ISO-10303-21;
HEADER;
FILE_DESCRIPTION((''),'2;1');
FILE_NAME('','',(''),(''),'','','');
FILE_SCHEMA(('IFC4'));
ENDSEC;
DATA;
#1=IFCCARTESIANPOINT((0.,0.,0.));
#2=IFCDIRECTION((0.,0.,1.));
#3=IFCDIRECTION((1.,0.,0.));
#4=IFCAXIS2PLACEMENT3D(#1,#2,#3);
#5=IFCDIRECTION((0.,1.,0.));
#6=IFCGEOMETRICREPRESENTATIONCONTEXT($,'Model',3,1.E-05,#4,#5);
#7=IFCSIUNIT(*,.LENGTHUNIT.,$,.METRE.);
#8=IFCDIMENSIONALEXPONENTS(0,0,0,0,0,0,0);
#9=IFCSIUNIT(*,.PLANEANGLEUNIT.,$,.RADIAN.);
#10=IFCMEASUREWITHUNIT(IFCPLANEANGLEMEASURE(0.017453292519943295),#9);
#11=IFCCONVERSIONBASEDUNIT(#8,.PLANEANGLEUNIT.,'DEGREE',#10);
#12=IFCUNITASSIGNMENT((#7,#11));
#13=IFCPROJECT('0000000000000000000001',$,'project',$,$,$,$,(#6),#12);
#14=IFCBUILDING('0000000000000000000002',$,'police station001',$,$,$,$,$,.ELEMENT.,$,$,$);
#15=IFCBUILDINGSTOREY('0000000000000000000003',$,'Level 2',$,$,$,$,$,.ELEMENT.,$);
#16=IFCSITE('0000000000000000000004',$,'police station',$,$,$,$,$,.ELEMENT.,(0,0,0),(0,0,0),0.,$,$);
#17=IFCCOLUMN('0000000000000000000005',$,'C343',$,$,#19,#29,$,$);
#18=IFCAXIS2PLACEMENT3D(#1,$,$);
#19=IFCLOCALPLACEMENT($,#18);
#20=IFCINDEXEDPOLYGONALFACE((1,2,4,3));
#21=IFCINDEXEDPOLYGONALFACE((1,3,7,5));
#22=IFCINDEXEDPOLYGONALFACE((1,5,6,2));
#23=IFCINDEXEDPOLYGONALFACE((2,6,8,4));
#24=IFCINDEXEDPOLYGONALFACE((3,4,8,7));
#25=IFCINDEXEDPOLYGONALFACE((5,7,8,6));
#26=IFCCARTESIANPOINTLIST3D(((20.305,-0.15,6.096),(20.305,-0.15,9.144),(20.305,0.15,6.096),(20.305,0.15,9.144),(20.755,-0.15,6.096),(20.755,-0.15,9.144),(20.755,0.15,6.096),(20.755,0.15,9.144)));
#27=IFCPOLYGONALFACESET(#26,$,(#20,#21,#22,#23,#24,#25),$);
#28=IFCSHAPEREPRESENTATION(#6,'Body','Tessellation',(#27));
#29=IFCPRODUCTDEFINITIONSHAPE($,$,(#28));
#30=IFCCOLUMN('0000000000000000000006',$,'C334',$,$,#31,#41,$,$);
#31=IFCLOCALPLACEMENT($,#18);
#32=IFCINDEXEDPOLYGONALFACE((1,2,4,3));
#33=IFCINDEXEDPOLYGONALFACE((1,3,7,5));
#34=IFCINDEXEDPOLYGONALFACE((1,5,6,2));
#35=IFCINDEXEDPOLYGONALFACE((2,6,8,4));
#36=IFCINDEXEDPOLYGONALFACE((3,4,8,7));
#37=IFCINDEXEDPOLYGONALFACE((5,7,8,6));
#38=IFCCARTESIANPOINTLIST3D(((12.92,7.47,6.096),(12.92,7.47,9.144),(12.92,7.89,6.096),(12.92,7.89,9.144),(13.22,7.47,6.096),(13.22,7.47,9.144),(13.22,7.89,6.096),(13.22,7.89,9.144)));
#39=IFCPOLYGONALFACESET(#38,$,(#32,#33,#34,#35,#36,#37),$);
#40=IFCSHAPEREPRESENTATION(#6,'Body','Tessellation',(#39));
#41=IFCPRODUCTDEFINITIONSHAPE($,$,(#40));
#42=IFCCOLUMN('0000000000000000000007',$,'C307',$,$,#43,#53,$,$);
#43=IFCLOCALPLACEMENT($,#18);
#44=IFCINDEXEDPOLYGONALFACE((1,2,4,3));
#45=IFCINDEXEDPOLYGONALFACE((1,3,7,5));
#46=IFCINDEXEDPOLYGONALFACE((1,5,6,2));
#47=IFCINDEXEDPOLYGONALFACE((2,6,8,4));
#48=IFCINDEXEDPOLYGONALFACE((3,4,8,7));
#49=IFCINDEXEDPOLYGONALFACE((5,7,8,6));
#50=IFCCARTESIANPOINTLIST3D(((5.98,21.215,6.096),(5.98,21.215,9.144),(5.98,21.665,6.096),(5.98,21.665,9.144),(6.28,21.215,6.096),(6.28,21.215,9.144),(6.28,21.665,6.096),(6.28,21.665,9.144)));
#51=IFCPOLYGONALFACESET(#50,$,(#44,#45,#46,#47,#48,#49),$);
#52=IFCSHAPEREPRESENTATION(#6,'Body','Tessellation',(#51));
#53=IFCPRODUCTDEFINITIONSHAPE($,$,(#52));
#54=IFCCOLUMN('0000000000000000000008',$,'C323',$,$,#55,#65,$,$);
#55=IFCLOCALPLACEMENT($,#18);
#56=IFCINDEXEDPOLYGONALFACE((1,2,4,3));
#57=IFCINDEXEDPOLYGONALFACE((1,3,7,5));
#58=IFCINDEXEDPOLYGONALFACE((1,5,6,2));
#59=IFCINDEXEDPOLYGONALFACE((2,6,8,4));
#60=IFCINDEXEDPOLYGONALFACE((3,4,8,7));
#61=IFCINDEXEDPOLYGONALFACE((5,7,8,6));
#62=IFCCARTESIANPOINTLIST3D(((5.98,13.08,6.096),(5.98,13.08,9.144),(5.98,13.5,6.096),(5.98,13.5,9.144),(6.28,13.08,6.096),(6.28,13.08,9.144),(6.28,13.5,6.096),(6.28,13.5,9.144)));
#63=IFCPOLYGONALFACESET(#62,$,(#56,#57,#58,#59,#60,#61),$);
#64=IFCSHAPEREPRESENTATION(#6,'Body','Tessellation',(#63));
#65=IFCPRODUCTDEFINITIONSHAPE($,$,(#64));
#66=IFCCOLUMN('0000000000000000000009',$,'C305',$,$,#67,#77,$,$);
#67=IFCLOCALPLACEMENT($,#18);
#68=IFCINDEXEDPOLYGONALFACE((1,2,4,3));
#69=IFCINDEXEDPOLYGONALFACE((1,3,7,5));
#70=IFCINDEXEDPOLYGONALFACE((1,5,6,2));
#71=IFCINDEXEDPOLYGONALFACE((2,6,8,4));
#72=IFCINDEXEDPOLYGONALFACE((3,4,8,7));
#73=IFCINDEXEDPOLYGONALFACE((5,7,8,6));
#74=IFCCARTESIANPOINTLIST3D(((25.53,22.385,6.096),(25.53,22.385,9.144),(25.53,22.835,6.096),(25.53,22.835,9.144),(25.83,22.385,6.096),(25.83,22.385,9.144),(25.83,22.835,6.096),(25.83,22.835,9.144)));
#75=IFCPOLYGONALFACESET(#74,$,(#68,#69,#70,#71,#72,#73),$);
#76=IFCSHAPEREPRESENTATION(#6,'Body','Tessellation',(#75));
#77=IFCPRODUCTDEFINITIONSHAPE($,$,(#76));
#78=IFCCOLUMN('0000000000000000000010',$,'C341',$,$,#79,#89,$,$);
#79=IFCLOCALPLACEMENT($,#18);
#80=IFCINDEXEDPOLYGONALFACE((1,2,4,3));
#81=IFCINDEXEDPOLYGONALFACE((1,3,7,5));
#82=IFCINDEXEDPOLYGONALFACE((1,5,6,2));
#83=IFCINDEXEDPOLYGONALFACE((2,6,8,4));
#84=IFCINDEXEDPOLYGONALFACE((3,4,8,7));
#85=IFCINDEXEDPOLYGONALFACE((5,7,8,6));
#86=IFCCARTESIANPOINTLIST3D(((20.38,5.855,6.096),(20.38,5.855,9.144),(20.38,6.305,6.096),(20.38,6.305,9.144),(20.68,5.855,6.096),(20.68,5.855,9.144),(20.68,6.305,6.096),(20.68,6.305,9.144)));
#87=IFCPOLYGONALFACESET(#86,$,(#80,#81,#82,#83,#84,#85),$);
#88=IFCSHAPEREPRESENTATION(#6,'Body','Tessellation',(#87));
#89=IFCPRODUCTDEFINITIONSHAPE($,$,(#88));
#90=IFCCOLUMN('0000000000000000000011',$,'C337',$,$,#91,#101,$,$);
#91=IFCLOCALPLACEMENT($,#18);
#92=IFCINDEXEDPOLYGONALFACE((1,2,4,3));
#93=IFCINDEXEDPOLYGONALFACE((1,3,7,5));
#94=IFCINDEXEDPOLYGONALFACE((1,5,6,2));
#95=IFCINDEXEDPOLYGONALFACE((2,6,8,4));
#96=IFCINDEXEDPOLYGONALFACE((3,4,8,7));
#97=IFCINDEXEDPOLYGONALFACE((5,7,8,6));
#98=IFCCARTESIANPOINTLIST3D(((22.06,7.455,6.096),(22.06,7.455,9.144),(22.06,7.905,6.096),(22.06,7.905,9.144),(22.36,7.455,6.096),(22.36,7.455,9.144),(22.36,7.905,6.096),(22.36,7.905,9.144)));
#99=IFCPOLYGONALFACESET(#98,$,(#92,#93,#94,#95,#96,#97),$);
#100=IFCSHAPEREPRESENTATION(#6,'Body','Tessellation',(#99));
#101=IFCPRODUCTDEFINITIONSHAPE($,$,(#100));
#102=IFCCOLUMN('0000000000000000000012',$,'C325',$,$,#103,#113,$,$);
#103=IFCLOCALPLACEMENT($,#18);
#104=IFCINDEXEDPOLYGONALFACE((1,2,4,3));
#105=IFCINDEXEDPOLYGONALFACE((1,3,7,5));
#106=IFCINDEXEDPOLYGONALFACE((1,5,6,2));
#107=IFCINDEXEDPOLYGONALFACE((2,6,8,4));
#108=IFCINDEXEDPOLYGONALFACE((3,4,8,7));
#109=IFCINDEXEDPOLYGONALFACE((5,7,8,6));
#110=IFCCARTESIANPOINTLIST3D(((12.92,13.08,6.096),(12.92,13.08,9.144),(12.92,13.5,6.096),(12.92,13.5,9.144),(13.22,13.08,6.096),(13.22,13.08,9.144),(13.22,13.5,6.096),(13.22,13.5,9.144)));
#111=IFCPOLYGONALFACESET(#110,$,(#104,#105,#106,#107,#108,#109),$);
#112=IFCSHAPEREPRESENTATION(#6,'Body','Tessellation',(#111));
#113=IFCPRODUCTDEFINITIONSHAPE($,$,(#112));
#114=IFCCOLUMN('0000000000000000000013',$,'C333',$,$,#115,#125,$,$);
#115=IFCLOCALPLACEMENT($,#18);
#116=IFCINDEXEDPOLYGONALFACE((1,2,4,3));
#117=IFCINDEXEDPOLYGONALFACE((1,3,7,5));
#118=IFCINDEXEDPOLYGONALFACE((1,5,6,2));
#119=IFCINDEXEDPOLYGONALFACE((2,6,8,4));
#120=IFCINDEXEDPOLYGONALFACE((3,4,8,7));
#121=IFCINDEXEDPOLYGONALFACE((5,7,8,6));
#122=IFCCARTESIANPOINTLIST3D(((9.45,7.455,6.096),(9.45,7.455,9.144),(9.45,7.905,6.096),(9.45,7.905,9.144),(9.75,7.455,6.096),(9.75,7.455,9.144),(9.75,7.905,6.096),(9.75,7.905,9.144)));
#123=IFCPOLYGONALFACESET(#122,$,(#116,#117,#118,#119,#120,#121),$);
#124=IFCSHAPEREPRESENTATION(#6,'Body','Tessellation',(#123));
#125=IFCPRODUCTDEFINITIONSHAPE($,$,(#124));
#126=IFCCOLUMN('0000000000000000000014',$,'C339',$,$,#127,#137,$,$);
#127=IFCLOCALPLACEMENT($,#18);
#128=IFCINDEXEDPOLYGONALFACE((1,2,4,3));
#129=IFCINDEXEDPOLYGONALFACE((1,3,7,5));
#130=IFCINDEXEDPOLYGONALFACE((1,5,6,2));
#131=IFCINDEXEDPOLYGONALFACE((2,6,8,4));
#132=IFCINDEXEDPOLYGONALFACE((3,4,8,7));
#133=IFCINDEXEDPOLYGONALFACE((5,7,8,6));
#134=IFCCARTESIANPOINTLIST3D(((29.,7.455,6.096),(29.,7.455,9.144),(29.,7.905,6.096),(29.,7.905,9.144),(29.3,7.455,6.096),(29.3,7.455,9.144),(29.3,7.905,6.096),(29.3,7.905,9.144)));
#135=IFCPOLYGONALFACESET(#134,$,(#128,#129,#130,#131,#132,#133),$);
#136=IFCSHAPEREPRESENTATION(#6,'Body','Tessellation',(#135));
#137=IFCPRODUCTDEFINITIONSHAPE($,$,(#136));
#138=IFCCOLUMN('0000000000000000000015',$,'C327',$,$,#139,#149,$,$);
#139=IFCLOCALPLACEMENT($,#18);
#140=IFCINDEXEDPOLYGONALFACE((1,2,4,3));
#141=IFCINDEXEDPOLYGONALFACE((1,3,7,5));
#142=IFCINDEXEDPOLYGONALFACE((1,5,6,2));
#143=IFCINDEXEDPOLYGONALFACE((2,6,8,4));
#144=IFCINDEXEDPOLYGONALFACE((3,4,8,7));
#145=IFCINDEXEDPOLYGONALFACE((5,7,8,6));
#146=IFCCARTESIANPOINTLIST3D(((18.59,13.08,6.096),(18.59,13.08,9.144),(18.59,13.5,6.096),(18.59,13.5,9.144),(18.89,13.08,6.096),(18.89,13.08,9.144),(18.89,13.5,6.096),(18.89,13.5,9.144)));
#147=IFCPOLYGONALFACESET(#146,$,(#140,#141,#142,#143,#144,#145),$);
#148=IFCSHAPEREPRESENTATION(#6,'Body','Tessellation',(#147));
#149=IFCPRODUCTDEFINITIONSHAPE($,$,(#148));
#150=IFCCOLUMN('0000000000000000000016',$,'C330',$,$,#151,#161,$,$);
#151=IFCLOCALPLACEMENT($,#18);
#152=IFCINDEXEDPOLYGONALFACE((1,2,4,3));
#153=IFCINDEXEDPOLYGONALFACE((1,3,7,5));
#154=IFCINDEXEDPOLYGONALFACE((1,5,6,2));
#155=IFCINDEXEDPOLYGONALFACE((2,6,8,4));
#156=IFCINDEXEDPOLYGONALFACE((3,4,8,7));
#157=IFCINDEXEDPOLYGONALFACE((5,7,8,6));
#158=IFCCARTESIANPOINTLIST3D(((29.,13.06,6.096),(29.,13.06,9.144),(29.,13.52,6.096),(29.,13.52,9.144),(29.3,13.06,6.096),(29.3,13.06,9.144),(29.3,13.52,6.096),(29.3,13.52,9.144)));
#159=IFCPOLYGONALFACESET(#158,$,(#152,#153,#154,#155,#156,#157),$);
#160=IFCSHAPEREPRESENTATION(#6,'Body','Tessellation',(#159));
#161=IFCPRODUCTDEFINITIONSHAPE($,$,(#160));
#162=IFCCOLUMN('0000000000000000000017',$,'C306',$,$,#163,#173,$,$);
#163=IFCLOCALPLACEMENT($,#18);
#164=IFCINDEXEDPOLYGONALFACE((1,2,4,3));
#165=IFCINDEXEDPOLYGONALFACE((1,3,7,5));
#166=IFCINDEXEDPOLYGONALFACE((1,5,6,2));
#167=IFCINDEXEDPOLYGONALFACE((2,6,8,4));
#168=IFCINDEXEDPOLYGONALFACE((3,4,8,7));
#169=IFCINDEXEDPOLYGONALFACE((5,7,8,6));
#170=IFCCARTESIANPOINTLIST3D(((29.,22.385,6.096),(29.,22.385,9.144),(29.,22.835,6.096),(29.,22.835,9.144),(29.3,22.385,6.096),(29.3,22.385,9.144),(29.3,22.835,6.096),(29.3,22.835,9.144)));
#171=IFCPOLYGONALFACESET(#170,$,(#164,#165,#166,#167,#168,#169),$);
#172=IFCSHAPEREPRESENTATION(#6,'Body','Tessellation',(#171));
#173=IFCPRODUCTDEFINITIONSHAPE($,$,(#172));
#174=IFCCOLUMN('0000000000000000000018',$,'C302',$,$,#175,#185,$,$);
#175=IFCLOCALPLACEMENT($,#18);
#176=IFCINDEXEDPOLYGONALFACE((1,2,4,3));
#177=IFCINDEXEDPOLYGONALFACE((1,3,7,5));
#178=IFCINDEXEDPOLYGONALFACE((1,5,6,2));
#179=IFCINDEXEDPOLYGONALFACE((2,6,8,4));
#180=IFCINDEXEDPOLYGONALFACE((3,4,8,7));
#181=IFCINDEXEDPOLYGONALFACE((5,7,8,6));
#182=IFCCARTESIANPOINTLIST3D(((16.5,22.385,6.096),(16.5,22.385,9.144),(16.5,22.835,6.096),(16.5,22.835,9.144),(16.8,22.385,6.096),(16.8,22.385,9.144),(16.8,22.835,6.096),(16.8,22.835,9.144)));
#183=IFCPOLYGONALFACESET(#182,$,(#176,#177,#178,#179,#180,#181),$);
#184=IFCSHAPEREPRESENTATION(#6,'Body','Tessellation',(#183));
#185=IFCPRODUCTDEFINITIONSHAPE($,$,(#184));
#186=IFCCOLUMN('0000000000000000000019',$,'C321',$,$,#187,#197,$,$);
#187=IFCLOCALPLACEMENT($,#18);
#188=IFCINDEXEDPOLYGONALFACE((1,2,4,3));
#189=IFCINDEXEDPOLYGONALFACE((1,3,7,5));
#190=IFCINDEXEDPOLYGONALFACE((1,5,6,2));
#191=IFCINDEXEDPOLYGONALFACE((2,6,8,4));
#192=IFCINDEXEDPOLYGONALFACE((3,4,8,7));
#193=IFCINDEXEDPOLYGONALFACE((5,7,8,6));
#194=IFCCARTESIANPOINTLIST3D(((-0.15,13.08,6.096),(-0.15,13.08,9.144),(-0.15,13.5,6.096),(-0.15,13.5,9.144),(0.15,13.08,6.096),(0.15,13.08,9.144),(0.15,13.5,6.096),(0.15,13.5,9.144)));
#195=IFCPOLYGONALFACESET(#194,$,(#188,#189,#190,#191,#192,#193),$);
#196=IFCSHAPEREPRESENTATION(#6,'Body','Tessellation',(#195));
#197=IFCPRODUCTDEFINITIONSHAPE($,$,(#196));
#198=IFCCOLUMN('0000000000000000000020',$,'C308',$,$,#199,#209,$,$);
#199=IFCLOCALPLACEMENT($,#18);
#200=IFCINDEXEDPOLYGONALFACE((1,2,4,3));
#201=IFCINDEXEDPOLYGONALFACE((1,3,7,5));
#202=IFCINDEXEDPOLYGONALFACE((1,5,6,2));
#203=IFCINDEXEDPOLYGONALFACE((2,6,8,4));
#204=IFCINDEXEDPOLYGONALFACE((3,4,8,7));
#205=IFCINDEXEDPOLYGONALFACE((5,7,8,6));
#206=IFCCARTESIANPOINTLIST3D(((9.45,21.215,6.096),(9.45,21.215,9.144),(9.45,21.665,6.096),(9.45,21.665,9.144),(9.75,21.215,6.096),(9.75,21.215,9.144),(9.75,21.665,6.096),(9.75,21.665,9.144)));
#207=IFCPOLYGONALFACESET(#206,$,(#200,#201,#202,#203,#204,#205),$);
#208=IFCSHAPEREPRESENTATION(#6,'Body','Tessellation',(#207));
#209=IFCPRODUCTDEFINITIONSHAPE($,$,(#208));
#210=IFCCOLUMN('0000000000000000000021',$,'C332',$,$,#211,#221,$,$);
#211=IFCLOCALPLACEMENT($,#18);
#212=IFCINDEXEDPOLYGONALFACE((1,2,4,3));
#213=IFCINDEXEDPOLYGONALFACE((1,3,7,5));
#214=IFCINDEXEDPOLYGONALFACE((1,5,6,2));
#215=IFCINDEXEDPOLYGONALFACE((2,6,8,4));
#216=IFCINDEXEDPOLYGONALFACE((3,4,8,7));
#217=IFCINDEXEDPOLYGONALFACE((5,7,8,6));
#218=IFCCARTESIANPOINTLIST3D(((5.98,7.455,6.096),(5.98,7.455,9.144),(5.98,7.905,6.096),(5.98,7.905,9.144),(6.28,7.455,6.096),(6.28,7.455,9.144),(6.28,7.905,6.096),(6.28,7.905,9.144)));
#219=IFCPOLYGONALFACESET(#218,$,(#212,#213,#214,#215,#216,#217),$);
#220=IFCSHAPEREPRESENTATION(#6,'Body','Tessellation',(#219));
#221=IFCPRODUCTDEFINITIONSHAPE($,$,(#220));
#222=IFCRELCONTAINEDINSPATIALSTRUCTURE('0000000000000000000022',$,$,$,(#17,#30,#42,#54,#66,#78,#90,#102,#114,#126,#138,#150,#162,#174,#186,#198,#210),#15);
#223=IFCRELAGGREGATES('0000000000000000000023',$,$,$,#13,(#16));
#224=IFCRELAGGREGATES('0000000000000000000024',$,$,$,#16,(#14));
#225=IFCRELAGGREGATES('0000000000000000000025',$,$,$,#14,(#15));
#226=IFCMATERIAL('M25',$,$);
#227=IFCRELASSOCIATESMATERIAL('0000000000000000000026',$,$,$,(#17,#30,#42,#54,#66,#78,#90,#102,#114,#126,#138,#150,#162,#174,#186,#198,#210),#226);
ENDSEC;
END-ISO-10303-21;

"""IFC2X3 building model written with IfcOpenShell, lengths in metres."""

from ifc_helpers import new_model, entity, si_unit, converted_unit, direction, frame, frame_2d, origin_with_axes, place, context, project, spatial, rectangle, extrude, material, element, save


model = new_model("IFC2X3")

# Units and contexts
model_context = context("Model", 3, precision=1e-05, world=origin_with_axes(), true_north=direction((0.0, 1.0, 0.0)))
ifc_project = project(units=[si_unit("LENGTHUNIT", "METRE"), converted_unit("PLANEANGLEUNIT", "DEGREE", entity("IfcPlaneAngleMeasure", 0.017453292519943295), si_unit("PLANEANGLEUNIT", "RADIAN"), dimensions=[0, 0, 0, 0, 0, 0, 0])], contexts=[model_context])

# Site, building, storey
site = spatial("IfcSite", under=ifc_project, Name="police station", CompositionType="ELEMENT", RefLatitude=(0, 0, 0), RefLongitude=(0, 0, 0), RefElevation=0.0)
building = spatial("IfcBuilding", under=site, Name="police station001", CompositionType="ELEMENT")
storey = spatial("IfcBuildingStorey", under=building, Name="Level 2", CompositionType="ELEMENT")

# Columns
ifc_material = material(Name="M25")
placement = place(None, origin_with_axes())
element("IfcColumn", 1, at=placement, inside=storey, material=ifc_material, Name="C343", context=model_context, shape_type="SweptSolid", body=[
    extrude(rectangle(XDim=0.45, YDim=0.3, at=frame_2d((0.0, 0.0), x_axis=(1.0, 0.0, 0.0))), frame((20.53, 0.0, 6.096), z_axis=(0.0, 0.0, 1.0), x_axis=(1.0, 0.0, 0.0)), (0.0, 0.0, 1.0), 3.048),
])
element("IfcColumn", 2, at=placement, inside=storey, material=ifc_material, Name="C334", context=model_context, shape_type="SweptSolid", body=[
    extrude(rectangle(XDim=0.3, YDim=0.42, at=frame_2d((0.0, 0.0), x_axis=(1.0, 0.0, 0.0))), frame((13.07, 7.68, 6.096), z_axis=(0.0, 0.0, 1.0), x_axis=(1.0, 0.0, 0.0)), (0.0, 0.0, 1.0), 3.048),
])
element("IfcColumn", 3, at=placement, inside=storey, material=ifc_material, Name="C307", context=model_context, shape_type="SweptSolid", body=[
    extrude(rectangle(XDim=0.3, YDim=0.45, at=frame_2d((0.0, 0.0), x_axis=(1.0, 0.0, 0.0))), frame((6.13, 21.44, 6.096), z_axis=(0.0, 0.0, 1.0), x_axis=(1.0, 0.0, 0.0)), (0.0, 0.0, 1.0), 3.048),
])
element("IfcColumn", 4, at=placement, inside=storey, material=ifc_material, Name="C323", context=model_context, shape_type="SweptSolid", body=[
    extrude(rectangle(XDim=0.3, YDim=0.42, at=frame_2d((0.0, 0.0), x_axis=(1.0, 0.0, 0.0))), frame((6.13, 13.29, 6.096), z_axis=(0.0, 0.0, 1.0), x_axis=(1.0, 0.0, 0.0)), (0.0, 0.0, 1.0), 3.048),
])
element("IfcColumn", 5, at=placement, inside=storey, material=ifc_material, Name="C305", context=model_context, shape_type="SweptSolid", body=[
    extrude(rectangle(XDim=0.3, YDim=0.45, at=frame_2d((0.0, 0.0), x_axis=(1.0, 0.0, 0.0))), frame((25.68, 22.61, 6.096), z_axis=(0.0, 0.0, 1.0), x_axis=(1.0, 0.0, 0.0)), (0.0, 0.0, 1.0), 3.048),
])
element("IfcColumn", 6, at=placement, inside=storey, material=ifc_material, Name="C341", context=model_context, shape_type="SweptSolid", body=[
    extrude(rectangle(XDim=0.3, YDim=0.45, at=frame_2d((0.0, 0.0), x_axis=(1.0, 0.0, 0.0))), frame((20.53, 6.08, 6.096), z_axis=(0.0, 0.0, 1.0), x_axis=(1.0, 0.0, 0.0)), (0.0, 0.0, 1.0), 3.048),
])
element("IfcColumn", 7, at=placement, inside=storey, material=ifc_material, Name="C337", context=model_context, shape_type="SweptSolid", body=[
    extrude(rectangle(XDim=0.3, YDim=0.45, at=frame_2d((0.0, 0.0), x_axis=(1.0, 0.0, 0.0))), frame((22.21, 7.68, 6.096), z_axis=(0.0, 0.0, 1.0), x_axis=(1.0, 0.0, 0.0)), (0.0, 0.0, 1.0), 3.048),
])
element("IfcColumn", 8, at=placement, inside=storey, material=ifc_material, Name="C325", context=model_context, shape_type="SweptSolid", body=[
    extrude(rectangle(XDim=0.3, YDim=0.42, at=frame_2d((0.0, 0.0), x_axis=(1.0, 0.0, 0.0))), frame((13.07, 13.29, 6.096), z_axis=(0.0, 0.0, 1.0), x_axis=(1.0, 0.0, 0.0)), (0.0, 0.0, 1.0), 3.048),
])
element("IfcColumn", 9, at=placement, inside=storey, material=ifc_material, Name="C333", context=model_context, shape_type="SweptSolid", body=[
    extrude(rectangle(XDim=0.3, YDim=0.45, at=frame_2d((0.0, 0.0), x_axis=(1.0, 0.0, 0.0))), frame((9.6, 7.68, 6.096), z_axis=(0.0, 0.0, 1.0), x_axis=(1.0, 0.0, 0.0)), (0.0, 0.0, 1.0), 3.048),
])
element("IfcColumn", 10, at=placement, inside=storey, material=ifc_material, Name="C339", context=model_context, shape_type="SweptSolid", body=[
    extrude(rectangle(XDim=0.3, YDim=0.45, at=frame_2d((0.0, 0.0), x_axis=(1.0, 0.0, 0.0))), frame((29.15, 7.68, 6.096), z_axis=(0.0, 0.0, 1.0), x_axis=(1.0, 0.0, 0.0)), (0.0, 0.0, 1.0), 3.048),
])
element("IfcColumn", 11, at=placement, inside=storey, material=ifc_material, Name="C327", context=model_context, shape_type="SweptSolid", body=[
    extrude(rectangle(XDim=0.3, YDim=0.42, at=frame_2d((0.0, 0.0), x_axis=(1.0, 0.0, 0.0))), frame((18.74, 13.29, 6.096), z_axis=(0.0, 0.0, 1.0), x_axis=(1.0, 0.0, 0.0)), (0.0, 0.0, 1.0), 3.048),
])
element("IfcColumn", 12, at=placement, inside=storey, material=ifc_material, Name="C330", context=model_context, shape_type="SweptSolid", body=[
    extrude(rectangle(XDim=0.3, YDim=0.46, at=frame_2d((0.0, 0.0), x_axis=(1.0, 0.0, 0.0))), frame((29.15, 13.29, 6.096), z_axis=(0.0, 0.0, 1.0), x_axis=(1.0, 0.0, 0.0)), (0.0, 0.0, 1.0), 3.048),
])
element("IfcColumn", 13, at=placement, inside=storey, material=ifc_material, Name="C306", context=model_context, shape_type="SweptSolid", body=[
    extrude(rectangle(XDim=0.3, YDim=0.45, at=frame_2d((0.0, 0.0), x_axis=(1.0, 0.0, 0.0))), frame((29.15, 22.61, 6.096), z_axis=(0.0, 0.0, 1.0), x_axis=(1.0, 0.0, 0.0)), (0.0, 0.0, 1.0), 3.048),
])
element("IfcColumn", 14, at=placement, inside=storey, material=ifc_material, Name="C302", context=model_context, shape_type="SweptSolid", body=[
    extrude(rectangle(XDim=0.3, YDim=0.45, at=frame_2d((0.0, 0.0), x_axis=(1.0, 0.0, 0.0))), frame((16.65, 22.61, 6.096), z_axis=(0.0, 0.0, 1.0), x_axis=(1.0, 0.0, 0.0)), (0.0, 0.0, 1.0), 3.048),
])
element("IfcColumn", 15, at=placement, inside=storey, material=ifc_material, Name="C321", context=model_context, shape_type="SweptSolid", body=[
    extrude(rectangle(XDim=0.3, YDim=0.42, at=frame_2d((0.0, 0.0), x_axis=(1.0, 0.0, 0.0))), frame((0.0, 13.29, 6.096), z_axis=(0.0, 0.0, 1.0), x_axis=(1.0, 0.0, 0.0)), (0.0, 0.0, 1.0), 3.048),
])
element("IfcColumn", 16, at=placement, inside=storey, material=ifc_material, Name="C308", context=model_context, shape_type="SweptSolid", body=[
    extrude(rectangle(XDim=0.3, YDim=0.45, at=frame_2d((0.0, 0.0), x_axis=(1.0, 0.0, 0.0))), frame((9.6, 21.44, 6.096), z_axis=(0.0, 0.0, 1.0), x_axis=(1.0, 0.0, 0.0)), (0.0, 0.0, 1.0), 3.048),
])
element("IfcColumn", 17, at=placement, inside=storey, material=ifc_material, Name="C332", context=model_context, shape_type="SweptSolid", body=[
    extrude(rectangle(XDim=0.3, YDim=0.45, at=frame_2d((0.0, 0.0), x_axis=(1.0, 0.0, 0.0))), frame((6.13, 7.68, 6.096), z_axis=(0.0, 0.0, 1.0), x_axis=(1.0, 0.0, 0.0)), (0.0, 0.0, 1.0), 3.048),
])

save(model, "model.ifc")
